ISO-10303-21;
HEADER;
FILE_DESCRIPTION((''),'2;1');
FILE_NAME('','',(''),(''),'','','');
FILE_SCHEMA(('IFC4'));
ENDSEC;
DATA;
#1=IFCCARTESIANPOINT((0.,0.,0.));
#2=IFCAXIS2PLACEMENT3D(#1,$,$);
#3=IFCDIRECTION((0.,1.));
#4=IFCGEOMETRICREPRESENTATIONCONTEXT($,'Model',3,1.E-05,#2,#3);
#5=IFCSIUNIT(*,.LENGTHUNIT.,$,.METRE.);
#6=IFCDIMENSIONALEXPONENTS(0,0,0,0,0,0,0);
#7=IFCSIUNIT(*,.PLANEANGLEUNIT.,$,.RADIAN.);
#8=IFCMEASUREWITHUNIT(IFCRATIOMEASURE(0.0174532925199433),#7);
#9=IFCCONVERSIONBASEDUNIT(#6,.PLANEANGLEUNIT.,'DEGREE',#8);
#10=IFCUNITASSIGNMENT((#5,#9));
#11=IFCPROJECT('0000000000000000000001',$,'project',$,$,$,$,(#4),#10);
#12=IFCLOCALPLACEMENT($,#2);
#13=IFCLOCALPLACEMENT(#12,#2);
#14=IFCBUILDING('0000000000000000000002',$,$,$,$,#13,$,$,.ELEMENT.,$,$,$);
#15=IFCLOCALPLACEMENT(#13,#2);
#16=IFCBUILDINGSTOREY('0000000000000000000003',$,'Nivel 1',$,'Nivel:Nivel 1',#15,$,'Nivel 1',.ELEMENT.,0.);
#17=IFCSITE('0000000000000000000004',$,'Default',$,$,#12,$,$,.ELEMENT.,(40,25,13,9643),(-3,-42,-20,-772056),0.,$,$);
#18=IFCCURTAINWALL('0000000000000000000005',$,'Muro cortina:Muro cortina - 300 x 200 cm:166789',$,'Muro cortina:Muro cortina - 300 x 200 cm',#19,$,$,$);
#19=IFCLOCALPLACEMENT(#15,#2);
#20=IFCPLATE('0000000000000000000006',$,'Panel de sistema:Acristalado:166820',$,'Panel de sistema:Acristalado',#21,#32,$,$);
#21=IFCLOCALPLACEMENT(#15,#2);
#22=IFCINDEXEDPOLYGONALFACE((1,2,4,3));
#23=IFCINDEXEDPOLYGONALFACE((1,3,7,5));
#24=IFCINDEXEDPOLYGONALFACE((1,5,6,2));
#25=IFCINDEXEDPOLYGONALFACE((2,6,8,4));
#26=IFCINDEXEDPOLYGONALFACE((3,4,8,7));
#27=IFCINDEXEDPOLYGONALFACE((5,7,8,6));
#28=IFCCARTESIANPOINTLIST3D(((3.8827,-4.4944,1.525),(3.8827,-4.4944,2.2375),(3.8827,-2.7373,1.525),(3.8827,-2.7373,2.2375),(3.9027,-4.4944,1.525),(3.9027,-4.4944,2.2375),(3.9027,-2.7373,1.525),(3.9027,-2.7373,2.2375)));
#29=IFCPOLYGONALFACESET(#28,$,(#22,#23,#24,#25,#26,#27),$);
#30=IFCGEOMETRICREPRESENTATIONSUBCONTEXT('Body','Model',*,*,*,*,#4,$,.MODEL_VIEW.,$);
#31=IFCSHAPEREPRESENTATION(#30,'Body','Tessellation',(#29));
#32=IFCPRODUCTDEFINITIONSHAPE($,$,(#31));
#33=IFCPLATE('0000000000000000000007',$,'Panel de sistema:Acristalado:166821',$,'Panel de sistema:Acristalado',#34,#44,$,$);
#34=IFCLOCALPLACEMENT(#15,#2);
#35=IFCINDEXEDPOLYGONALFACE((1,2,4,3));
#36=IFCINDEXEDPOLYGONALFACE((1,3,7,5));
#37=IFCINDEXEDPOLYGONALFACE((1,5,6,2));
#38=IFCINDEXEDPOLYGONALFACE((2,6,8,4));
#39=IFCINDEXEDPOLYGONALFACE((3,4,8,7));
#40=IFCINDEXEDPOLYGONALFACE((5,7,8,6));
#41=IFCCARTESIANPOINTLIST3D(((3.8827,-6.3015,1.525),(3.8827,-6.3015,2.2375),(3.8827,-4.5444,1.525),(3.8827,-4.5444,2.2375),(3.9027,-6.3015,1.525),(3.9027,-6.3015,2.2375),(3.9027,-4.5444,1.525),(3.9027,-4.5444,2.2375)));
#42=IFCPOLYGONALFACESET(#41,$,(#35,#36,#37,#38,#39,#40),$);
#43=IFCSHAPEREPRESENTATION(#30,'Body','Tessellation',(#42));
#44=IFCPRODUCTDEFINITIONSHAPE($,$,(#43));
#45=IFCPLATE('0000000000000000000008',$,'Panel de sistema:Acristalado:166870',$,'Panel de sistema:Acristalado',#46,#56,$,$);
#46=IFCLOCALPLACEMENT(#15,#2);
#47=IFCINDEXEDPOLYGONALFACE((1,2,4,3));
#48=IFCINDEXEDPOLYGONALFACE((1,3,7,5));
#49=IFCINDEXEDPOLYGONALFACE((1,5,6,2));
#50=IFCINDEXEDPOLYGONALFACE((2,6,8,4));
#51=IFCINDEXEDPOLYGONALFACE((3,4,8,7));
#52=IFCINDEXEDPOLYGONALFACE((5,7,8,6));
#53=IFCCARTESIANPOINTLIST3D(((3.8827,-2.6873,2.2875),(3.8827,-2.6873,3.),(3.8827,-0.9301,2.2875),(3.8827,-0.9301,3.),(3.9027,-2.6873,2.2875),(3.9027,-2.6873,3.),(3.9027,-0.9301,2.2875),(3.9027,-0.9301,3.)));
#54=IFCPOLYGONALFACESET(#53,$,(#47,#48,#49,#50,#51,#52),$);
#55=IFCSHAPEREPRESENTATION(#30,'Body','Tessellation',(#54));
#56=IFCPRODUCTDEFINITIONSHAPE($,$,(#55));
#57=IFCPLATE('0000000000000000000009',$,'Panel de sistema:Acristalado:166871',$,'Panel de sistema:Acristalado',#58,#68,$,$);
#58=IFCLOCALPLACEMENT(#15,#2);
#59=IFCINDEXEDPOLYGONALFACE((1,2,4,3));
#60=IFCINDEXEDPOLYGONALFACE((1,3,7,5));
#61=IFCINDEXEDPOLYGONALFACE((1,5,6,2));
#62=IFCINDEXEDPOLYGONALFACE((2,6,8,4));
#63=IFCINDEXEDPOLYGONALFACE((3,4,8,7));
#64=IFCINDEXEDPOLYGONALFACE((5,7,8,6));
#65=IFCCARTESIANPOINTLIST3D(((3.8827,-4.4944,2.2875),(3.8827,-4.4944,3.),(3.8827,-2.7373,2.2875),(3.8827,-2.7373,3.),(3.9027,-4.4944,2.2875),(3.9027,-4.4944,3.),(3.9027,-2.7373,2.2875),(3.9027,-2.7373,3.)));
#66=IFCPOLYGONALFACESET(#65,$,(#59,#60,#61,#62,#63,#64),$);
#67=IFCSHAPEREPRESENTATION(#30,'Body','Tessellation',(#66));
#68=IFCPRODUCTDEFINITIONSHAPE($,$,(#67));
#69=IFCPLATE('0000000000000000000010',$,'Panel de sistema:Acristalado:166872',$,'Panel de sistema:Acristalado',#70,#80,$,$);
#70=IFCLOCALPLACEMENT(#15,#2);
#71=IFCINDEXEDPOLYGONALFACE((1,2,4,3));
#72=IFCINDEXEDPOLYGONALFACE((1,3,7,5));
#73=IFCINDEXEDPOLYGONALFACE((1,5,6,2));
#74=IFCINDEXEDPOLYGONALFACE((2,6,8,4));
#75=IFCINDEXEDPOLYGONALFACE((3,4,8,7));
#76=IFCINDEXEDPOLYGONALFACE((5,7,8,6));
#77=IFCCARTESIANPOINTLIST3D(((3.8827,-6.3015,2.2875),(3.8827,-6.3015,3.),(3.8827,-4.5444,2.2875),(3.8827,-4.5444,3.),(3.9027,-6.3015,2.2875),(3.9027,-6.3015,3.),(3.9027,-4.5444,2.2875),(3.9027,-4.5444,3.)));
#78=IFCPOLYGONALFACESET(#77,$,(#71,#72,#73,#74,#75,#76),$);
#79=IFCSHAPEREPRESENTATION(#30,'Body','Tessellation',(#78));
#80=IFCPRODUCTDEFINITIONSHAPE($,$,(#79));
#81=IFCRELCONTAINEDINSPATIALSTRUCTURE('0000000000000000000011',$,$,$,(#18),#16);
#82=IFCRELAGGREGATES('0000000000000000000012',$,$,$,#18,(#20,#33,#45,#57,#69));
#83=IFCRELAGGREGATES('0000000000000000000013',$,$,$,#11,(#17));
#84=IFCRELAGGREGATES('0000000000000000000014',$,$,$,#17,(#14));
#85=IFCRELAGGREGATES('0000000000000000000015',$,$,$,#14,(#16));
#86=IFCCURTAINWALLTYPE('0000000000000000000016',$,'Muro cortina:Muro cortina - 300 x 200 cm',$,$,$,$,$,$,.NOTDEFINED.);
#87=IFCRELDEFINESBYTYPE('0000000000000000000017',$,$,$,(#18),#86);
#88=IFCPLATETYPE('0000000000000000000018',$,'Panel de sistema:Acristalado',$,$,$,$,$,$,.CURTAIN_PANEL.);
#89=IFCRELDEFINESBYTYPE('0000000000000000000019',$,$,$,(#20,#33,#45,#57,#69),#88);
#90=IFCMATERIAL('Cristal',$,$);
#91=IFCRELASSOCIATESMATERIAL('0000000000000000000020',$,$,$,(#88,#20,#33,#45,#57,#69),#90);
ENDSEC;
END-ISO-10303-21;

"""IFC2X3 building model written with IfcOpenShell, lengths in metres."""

from ifc_helpers import new_model, entity, si_unit, converted_unit, direction, frame, origin, origin_2d_with_axis, place, context, subcontext, project, spatial, rectangle, extrude, source, transform, mapped, material, type_object, type_shapes, element, aggregate, save


model = new_model("IFC2X3")

# Units and contexts
model_context = context("Model", 3, precision=1e-05, world=origin(), true_north=direction((0.0, 1.0)))
body_context = subcontext(model_context, "Body", "Model", "MODEL_VIEW")
ifc_project = project(units=[si_unit("LENGTHUNIT", "METRE"), converted_unit("PLANEANGLEUNIT", "DEGREE", entity("IfcRatioMeasure", 0.0174532925199433), si_unit("PLANEANGLEUNIT", "RADIAN"), dimensions=[0, 0, 0, 0, 0, 0, 0])], contexts=[model_context])

# Site, building, storey
site_placement = place(None, origin())
site = spatial("IfcSite", under=ifc_project, at=site_placement, Name="Default", CompositionType="ELEMENT", RefLatitude=(40, 25, 13, 9643), RefLongitude=(-3, -42, -20, -772056), RefElevation=0.0)
building_placement = place(site_placement, origin())
building = spatial("IfcBuilding", under=site, at=building_placement, CompositionType="ELEMENT")
storey_placement = place(building_placement, origin())
storey = spatial("IfcBuildingStorey", under=building, at=storey_placement, Name="Nivel 1", ObjectType="Nivel:Nivel 1", LongName="Nivel 1", CompositionType="ELEMENT", Elevation=0.0)

# Curtain wall, plates
curtain_wall_type = type_object("IfcCurtainWallType", Name="Muro cortina:Muro cortina - 300 x 200 cm", PredefinedType="NOTDEFINED")
curtain_wall_placement = place(storey_placement, origin())
curtain_wall = element("IfcCurtainWall", 1, at=curtain_wall_placement, inside=storey, type_object=curtain_wall_type, Name="Muro cortina:Muro cortina - 300 x 200 cm:166789", ObjectType="Muro cortina:Muro cortina - 300 x 200 cm")
ifc_material_1 = material(Name="Cristal")
plate_type = type_object("IfcPlateType", Name="Panel de sistema:Acristalado", PredefinedType="CURTAIN_PANEL", material=ifc_material_1)
shared_shape_1 = source(origin(), body_context, "Body", "SweptSolid", [
    extrude(rectangle(XDim=0.02, YDim=1.7571, at=origin_2d_with_axis()), frame((0.0, 0.0, 0.0), z_axis=(0.0, 0.0, 1.0), x_axis=(0.0, 1.0, 0.0)), (0.0, 0.0, 1.0), 0.7125),
])
type_shapes(plate_type, [shared_shape_1])
plate_1_placement = place(curtain_wall_placement, frame((3.8927, -3.6158, 1.525), z_axis=(0.0, 0.0, 1.0), x_axis=(0.0, -1.0, 0.0)))
plate_1 = element("IfcPlate", 2, at=plate_1_placement, type_object=plate_type, material=ifc_material_1, Name="Panel de sistema:Acristalado:166820", ObjectType="Panel de sistema:Acristalado", context=body_context, shape_type="MappedRepresentation", body=[
    mapped(shared_shape_1, transform((0.0, 0.0, 0.0), scale=1.0)),
])
plate_2_placement = place(curtain_wall_placement, frame((3.8927, -5.423, 1.525), z_axis=(0.0, 0.0, 1.0), x_axis=(0.0, -1.0, 0.0)))
plate_2 = element("IfcPlate", 3, at=plate_2_placement, type_object=plate_type, material=ifc_material_1, Name="Panel de sistema:Acristalado:166821", ObjectType="Panel de sistema:Acristalado", context=body_context, shape_type="MappedRepresentation", body=[
    mapped(shared_shape_1, transform((0.0, 0.0, 0.0), scale=1.0)),
])
plate_3_placement = place(curtain_wall_placement, frame((3.8927, -1.8087, 2.2875), z_axis=(0.0, 0.0, 1.0), x_axis=(0.0, -1.0, 0.0)))
plate_3 = element("IfcPlate", 4, at=plate_3_placement, type_object=plate_type, material=ifc_material_1, Name="Panel de sistema:Acristalado:166870", ObjectType="Panel de sistema:Acristalado", context=body_context, shape_type="MappedRepresentation", body=[
    mapped(shared_shape_1, transform((0.0, 0.0, 0.0), scale=1.0)),
])
plate_4_placement = place(curtain_wall_placement, frame((3.8927, -3.6158, 2.2875), z_axis=(0.0, 0.0, 1.0), x_axis=(0.0, -1.0, 0.0)))
plate_4 = element("IfcPlate", 5, at=plate_4_placement, type_object=plate_type, material=ifc_material_1, Name="Panel de sistema:Acristalado:166871", ObjectType="Panel de sistema:Acristalado", context=body_context, shape_type="MappedRepresentation", body=[
    mapped(shared_shape_1, transform((0.0, 0.0, 0.0), scale=1.0)),
])
plate_5_placement = place(curtain_wall_placement, frame((3.8927, -5.423, 2.2875), z_axis=(0.0, 0.0, 1.0), x_axis=(0.0, -1.0, 0.0)))
plate_5 = element("IfcPlate", 6, at=plate_5_placement, type_object=plate_type, material=ifc_material_1, Name="Panel de sistema:Acristalado:166872", ObjectType="Panel de sistema:Acristalado", context=body_context, shape_type="MappedRepresentation", body=[
    mapped(shared_shape_1, transform((0.0, 0.0, 0.0), scale=1.0)),
])
aggregate(curtain_wall, [plate_1, plate_2, plate_3, plate_4, plate_5])

save(model, "model.ifc")
